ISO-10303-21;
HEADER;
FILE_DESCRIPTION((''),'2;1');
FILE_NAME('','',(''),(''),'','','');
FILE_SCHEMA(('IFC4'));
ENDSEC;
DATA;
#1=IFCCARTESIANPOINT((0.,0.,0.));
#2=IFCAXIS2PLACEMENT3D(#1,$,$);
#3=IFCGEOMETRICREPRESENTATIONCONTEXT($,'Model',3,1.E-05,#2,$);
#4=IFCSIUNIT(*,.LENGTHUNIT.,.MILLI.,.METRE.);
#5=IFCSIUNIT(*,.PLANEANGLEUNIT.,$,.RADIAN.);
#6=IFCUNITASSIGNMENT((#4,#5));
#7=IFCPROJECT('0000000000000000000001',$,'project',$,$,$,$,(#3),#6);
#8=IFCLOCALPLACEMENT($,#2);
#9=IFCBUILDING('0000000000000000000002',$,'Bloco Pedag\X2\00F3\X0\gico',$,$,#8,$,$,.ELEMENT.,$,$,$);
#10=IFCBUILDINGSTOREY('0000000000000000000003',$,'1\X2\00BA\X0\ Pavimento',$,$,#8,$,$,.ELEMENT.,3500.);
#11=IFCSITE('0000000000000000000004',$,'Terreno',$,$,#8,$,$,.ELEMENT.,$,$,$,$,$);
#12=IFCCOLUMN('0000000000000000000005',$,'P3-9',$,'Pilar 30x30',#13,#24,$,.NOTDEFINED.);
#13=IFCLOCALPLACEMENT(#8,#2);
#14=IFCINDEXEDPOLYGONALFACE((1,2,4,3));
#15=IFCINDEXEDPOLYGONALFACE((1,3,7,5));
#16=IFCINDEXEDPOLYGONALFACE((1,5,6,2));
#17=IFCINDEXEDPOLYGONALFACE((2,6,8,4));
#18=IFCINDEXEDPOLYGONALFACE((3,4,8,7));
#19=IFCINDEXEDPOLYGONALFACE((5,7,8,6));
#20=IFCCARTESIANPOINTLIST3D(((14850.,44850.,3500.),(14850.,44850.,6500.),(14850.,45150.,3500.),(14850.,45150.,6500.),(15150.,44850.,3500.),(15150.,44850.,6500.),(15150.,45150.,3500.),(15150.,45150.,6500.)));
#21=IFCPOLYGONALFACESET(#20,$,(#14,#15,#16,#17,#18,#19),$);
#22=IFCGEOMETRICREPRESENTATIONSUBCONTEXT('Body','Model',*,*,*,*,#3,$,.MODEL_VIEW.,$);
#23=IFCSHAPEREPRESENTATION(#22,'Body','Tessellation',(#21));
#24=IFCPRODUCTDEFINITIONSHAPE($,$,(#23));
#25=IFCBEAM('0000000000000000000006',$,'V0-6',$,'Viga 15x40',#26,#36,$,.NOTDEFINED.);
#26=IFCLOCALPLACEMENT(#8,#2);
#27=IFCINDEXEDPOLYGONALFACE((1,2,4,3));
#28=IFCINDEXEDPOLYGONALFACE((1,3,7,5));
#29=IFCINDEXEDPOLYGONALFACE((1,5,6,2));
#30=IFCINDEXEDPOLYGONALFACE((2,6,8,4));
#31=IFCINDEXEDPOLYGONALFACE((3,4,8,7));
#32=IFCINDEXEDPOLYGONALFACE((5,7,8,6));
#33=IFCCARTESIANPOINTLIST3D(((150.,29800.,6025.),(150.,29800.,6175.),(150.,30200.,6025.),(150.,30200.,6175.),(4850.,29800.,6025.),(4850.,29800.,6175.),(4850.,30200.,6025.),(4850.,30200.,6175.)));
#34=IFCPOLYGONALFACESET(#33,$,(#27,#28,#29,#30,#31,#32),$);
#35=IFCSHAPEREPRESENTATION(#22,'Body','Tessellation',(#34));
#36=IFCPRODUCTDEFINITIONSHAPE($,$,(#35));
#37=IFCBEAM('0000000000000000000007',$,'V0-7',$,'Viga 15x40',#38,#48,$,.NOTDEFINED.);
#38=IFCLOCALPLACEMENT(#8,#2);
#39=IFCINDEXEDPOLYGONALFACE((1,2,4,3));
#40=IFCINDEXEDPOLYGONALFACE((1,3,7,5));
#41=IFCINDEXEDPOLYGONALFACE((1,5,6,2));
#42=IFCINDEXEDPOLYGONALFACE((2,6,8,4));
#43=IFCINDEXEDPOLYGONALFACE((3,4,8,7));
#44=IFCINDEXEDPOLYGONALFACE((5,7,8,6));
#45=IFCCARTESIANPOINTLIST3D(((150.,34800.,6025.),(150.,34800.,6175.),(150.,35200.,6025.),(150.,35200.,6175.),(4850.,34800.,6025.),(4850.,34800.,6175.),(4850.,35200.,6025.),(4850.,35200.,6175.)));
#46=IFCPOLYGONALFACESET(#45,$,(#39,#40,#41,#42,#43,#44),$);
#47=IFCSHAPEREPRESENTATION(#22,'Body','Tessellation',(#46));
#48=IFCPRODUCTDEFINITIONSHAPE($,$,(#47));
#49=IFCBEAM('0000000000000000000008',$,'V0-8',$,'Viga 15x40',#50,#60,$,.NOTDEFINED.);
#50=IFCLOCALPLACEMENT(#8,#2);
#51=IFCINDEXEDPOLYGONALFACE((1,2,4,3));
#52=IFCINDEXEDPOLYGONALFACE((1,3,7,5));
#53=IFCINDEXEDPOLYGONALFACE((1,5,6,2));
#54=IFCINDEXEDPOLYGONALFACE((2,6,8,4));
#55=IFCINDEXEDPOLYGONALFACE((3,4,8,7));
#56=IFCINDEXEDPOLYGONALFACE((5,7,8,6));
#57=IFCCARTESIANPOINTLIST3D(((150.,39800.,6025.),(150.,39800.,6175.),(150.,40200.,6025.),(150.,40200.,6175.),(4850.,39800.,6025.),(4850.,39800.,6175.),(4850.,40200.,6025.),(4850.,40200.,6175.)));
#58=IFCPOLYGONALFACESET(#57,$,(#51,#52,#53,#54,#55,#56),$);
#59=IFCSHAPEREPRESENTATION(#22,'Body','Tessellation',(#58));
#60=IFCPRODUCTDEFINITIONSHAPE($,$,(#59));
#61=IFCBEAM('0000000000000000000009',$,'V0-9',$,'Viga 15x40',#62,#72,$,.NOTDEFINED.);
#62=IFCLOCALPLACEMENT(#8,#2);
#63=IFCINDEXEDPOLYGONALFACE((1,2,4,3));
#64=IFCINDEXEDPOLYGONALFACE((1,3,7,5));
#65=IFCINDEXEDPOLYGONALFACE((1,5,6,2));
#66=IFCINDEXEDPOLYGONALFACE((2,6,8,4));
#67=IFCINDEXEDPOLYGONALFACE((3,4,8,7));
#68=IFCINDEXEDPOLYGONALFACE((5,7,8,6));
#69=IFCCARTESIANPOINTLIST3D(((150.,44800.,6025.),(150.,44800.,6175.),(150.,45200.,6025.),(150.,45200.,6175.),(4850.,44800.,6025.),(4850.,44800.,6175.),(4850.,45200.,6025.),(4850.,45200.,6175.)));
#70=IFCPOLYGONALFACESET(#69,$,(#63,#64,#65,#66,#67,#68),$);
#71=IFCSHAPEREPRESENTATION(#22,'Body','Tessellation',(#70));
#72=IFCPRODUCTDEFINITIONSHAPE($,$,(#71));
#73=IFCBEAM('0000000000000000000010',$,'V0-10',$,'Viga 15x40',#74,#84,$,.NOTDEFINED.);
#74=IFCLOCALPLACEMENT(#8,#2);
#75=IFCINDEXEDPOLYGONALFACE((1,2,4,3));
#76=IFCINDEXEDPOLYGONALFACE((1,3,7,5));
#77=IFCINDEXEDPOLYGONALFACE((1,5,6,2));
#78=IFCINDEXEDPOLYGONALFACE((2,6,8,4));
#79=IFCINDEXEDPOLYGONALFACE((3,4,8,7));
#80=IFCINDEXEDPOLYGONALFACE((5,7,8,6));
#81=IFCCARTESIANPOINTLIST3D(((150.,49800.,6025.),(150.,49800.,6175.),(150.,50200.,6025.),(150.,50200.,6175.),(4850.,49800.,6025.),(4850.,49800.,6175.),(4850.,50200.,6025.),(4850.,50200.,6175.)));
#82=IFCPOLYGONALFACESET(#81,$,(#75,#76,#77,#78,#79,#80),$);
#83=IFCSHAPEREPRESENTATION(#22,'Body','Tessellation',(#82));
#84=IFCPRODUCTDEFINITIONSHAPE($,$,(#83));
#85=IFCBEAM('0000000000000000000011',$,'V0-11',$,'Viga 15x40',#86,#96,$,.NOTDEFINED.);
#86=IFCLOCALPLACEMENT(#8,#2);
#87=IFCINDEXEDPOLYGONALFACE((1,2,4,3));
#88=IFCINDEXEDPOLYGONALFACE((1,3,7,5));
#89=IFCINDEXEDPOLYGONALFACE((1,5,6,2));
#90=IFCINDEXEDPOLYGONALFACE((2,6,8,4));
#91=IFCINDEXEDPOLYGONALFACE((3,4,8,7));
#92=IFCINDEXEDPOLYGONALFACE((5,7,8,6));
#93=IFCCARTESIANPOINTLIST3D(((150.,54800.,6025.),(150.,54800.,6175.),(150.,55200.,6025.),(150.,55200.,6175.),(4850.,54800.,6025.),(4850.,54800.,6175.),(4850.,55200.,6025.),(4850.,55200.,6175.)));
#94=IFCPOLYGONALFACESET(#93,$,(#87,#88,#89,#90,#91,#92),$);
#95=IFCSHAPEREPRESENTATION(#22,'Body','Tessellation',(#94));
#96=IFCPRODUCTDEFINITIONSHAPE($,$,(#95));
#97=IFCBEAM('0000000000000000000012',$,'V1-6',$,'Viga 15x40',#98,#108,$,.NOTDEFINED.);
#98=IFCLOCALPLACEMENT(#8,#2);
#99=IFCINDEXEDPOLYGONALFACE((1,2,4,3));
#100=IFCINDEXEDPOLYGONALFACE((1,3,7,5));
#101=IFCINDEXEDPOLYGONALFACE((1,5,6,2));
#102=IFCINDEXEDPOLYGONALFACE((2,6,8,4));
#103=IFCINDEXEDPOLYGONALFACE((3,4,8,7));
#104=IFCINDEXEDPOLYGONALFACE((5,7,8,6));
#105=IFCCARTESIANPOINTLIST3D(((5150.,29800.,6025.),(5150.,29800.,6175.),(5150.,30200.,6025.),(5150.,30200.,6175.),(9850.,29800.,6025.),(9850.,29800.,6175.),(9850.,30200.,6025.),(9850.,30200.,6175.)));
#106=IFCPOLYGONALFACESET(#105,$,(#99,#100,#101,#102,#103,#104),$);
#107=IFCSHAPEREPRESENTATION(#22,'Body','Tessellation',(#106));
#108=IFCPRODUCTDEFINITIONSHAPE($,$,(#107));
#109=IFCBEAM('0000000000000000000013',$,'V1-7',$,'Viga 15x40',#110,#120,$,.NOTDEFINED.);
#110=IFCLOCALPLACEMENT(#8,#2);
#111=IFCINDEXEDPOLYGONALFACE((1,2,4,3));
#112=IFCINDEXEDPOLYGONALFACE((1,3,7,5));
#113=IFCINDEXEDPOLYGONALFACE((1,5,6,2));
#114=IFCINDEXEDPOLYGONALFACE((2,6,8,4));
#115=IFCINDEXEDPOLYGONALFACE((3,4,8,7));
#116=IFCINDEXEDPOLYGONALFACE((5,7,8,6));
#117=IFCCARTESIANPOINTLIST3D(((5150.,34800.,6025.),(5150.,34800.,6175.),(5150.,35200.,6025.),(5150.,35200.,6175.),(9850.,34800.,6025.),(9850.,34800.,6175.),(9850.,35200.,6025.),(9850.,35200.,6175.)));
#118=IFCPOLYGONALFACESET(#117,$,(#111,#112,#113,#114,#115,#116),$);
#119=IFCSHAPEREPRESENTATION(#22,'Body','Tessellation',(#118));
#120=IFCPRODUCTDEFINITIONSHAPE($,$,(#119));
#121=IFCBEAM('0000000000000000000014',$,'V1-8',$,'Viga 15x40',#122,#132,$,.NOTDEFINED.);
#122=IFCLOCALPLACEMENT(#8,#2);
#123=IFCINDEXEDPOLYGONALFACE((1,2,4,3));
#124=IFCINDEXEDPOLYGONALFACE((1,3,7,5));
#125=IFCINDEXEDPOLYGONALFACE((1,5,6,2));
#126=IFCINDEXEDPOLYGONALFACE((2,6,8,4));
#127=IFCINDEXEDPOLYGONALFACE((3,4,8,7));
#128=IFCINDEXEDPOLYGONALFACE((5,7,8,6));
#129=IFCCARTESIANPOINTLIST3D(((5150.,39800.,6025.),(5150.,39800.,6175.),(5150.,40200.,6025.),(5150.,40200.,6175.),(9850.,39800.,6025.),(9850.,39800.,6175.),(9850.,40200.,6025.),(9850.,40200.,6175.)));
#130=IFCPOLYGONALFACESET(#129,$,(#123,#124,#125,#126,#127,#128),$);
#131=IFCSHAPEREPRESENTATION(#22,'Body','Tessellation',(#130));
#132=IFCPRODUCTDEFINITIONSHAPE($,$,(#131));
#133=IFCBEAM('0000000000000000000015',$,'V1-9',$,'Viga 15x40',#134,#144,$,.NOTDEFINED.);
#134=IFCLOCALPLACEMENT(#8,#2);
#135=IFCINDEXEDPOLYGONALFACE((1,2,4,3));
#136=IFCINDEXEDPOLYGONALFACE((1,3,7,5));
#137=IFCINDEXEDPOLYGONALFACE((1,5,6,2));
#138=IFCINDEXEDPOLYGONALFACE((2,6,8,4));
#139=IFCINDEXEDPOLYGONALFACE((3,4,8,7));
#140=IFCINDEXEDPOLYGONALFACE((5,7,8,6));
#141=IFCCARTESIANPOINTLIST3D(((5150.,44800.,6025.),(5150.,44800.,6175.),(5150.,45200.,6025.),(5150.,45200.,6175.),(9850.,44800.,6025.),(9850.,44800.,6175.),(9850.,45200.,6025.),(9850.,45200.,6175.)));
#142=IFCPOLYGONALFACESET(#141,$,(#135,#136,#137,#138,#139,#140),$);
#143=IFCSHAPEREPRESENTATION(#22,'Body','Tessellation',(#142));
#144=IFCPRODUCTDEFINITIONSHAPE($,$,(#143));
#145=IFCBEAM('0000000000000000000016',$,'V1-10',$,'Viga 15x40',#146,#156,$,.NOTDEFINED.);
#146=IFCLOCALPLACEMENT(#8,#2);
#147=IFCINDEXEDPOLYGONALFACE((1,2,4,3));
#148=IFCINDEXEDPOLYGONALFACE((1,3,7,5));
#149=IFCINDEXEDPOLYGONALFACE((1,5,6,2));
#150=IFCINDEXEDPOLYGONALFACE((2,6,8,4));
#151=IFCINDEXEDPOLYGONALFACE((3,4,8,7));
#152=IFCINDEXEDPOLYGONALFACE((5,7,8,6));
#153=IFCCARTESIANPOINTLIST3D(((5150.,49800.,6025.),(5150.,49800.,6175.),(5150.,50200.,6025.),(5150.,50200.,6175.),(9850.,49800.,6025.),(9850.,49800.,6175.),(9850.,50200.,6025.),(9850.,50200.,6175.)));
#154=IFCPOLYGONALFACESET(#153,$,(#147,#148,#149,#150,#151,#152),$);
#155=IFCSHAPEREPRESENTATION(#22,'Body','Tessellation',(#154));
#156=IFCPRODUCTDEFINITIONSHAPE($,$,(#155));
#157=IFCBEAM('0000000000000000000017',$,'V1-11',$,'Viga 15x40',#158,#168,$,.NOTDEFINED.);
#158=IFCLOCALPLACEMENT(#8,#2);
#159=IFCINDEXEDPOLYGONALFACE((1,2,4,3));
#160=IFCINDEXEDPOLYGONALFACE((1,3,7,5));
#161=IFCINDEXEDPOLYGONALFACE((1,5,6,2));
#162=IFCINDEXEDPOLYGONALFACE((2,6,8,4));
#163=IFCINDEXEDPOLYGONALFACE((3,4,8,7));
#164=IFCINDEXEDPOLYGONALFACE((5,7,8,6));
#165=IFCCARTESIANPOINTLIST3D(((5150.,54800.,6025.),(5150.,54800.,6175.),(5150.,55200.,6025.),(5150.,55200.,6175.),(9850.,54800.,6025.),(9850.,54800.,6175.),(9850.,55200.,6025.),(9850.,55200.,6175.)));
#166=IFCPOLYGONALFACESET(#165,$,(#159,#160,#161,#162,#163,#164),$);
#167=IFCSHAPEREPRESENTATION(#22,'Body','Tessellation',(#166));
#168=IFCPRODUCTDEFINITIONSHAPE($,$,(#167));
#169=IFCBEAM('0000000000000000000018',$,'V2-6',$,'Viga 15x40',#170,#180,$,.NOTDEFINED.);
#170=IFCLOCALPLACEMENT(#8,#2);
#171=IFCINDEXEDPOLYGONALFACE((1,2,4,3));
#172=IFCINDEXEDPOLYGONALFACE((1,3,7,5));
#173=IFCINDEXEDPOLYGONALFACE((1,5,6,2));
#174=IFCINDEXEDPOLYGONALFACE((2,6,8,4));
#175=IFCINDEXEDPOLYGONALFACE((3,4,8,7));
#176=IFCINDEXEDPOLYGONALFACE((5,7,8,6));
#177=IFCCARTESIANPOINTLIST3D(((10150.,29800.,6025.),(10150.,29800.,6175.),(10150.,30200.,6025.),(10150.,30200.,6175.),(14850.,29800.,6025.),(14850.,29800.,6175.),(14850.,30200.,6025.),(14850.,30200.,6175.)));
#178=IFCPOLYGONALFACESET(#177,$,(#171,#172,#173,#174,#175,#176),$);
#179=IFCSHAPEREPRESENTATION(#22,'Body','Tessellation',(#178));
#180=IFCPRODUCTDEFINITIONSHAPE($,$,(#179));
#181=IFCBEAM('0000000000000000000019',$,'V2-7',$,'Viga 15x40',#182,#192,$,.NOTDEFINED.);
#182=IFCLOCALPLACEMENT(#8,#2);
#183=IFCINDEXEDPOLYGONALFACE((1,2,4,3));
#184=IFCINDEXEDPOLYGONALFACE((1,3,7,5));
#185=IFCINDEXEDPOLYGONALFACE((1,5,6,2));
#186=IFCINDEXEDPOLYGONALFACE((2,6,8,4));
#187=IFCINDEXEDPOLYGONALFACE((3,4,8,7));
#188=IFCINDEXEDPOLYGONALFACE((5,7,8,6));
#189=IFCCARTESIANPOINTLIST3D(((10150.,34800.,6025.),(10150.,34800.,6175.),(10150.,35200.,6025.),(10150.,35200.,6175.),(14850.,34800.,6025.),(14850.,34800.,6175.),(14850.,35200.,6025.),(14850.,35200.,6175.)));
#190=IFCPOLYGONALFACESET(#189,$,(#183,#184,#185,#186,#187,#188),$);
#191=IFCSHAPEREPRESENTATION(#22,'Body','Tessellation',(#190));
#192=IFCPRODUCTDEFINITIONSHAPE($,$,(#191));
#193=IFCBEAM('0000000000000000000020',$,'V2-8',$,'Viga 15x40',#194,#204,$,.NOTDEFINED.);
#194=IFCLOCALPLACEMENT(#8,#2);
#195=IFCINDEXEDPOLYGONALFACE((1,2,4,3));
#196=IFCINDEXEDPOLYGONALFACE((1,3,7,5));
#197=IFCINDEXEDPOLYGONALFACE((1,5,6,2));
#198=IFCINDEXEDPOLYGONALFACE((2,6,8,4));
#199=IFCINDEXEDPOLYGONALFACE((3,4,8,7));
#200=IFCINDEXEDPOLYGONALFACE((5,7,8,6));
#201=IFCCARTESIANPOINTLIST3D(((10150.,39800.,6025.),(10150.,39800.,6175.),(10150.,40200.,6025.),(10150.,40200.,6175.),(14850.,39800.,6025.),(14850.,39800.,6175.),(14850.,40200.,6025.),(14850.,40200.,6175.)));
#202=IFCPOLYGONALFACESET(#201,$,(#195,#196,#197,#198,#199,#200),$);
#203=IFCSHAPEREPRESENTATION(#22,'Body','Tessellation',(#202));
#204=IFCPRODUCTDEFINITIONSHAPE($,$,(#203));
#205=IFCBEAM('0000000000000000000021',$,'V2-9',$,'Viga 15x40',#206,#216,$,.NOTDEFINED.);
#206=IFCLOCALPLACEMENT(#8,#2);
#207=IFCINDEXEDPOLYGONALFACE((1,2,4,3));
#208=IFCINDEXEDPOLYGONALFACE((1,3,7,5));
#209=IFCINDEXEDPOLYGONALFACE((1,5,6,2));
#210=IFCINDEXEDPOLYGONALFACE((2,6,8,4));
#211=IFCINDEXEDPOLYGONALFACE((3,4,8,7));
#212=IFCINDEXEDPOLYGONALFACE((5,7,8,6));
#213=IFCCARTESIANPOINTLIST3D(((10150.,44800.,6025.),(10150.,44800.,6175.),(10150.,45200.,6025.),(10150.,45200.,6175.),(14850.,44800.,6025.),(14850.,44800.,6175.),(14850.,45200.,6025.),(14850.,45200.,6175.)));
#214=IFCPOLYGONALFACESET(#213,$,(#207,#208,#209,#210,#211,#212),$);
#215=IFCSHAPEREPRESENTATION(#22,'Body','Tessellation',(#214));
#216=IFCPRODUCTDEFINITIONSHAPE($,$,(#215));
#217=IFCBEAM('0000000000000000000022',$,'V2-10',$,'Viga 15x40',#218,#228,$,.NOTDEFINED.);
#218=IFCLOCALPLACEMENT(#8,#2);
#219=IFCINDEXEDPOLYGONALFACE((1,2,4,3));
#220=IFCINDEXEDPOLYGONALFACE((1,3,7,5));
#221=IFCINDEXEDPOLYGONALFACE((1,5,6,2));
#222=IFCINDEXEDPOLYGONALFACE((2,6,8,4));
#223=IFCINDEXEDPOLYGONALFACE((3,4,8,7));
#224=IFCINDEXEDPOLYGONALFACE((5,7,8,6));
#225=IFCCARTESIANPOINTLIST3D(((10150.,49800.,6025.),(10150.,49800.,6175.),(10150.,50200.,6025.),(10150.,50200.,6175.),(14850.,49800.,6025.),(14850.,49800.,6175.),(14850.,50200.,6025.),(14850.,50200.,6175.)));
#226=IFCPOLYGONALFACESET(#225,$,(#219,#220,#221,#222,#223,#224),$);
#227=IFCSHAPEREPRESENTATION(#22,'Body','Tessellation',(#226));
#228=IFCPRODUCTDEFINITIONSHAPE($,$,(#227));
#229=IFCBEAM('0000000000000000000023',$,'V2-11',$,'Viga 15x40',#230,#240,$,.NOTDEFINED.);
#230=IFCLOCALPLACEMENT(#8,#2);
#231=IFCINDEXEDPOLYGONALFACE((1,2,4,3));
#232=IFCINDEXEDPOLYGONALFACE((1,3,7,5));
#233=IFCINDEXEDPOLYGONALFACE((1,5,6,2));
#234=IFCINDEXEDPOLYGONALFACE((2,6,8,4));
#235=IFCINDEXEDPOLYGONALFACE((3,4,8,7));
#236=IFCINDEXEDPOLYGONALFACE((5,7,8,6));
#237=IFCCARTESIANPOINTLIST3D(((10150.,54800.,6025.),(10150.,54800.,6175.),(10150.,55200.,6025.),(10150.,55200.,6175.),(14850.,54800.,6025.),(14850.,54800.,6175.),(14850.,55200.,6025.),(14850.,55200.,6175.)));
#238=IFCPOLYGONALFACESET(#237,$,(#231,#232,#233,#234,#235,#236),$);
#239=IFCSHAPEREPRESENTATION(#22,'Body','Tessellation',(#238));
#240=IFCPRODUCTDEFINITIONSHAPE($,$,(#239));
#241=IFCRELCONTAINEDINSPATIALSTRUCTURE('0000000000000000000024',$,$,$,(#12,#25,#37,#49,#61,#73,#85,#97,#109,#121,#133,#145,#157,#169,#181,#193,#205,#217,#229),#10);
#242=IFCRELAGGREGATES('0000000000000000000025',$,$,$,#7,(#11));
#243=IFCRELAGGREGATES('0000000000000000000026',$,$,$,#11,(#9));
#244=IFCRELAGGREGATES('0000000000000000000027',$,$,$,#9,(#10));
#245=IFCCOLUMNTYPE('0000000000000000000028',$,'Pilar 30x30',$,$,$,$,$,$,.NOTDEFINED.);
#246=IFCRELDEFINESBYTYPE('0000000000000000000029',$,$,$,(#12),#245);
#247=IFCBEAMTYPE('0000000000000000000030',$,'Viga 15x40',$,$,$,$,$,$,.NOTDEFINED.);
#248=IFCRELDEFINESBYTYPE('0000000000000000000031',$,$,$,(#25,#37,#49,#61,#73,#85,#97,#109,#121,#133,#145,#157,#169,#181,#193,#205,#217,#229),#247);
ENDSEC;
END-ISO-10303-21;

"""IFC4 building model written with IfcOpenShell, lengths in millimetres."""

from ifc_helpers import new_model, si_unit, frame, origin, origin_2d, place, context, subcontext, project, spatial, rectangle, extrude, type_object, element, save


model = new_model("IFC4")

# Units and contexts
model_context = context("Model", 3, precision=1e-05, world=origin())
body_context = subcontext(model_context, "Body", "Model", "MODEL_VIEW")
ifc_project = project(units=[si_unit("LENGTHUNIT", "METRE", prefix="MILLI"), si_unit("PLANEANGLEUNIT", "RADIAN")], contexts=[model_context])

# Site, building, storey
placement = place(None, origin())
site = spatial("IfcSite", under=ifc_project, at=placement, Name="Terreno", CompositionType="ELEMENT")
building = spatial("IfcBuilding", under=site, at=placement, Name="Bloco Pedagógico", CompositionType="ELEMENT")
storey = spatial("IfcBuildingStorey", under=building, at=placement, Name="1º Pavimento", CompositionType="ELEMENT", Elevation=3500.0)

# Column
column_type = type_object("IfcColumnType", Name="Pilar 30x30", PredefinedType="NOTDEFINED")
for number, where, z_axis, x_axis, name in (
    (1, (15000.0, 45000.0, 3500.0), (0.0, 0.0, 1.0), (1.0, 0.0, 0.0), "P3-9"),
):
    element("IfcColumn", number, at=place(None, frame(where, z_axis=z_axis, x_axis=x_axis)), inside=storey, type_object=column_type, Name=name, ObjectType="Pilar 30x30", PredefinedType="NOTDEFINED", context=body_context, shape_type="SweptSolid", body=[
        extrude(rectangle(XDim=300.0, YDim=300.0, at=origin_2d()), None, (0.0, 0.0, 1.0), 3000.0),
    ])

# Beams
beam_type = type_object("IfcBeamType", Name="Viga 15x40", PredefinedType="NOTDEFINED")
for number, where, z_axis, x_axis, name in (
    (2, (150.0, 30000.0, 6100.0), (1.0, 0.0, 0.0), (0.0, 1.0, 0.0), "V0-6"),
    (3, (150.0, 35000.0, 6100.0), (1.0, 0.0, 0.0), (0.0, 1.0, 0.0), "V0-7"),
    (4, (150.0, 40000.0, 6100.0), (1.0, 0.0, 0.0), (0.0, 1.0, 0.0), "V0-8"),
    (5, (150.0, 45000.0, 6100.0), (1.0, 0.0, 0.0), (0.0, 1.0, 0.0), "V0-9"),
    (6, (150.0, 50000.0, 6100.0), (1.0, 0.0, 0.0), (0.0, 1.0, 0.0), "V0-10"),
    (7, (150.0, 55000.0, 6100.0), (1.0, 0.0, 0.0), (0.0, 1.0, 0.0), "V0-11"),
    (8, (5150.0, 30000.0, 6100.0), (1.0, 0.0, 0.0), (0.0, 1.0, 0.0), "V1-6"),
    (9, (5150.0, 35000.0, 6100.0), (1.0, 0.0, 0.0), (0.0, 1.0, 0.0), "V1-7"),
    (10, (5150.0, 40000.0, 6100.0), (1.0, 0.0, 0.0), (0.0, 1.0, 0.0), "V1-8"),
    (11, (5150.0, 45000.0, 6100.0), (1.0, 0.0, 0.0), (0.0, 1.0, 0.0), "V1-9"),
    (12, (5150.0, 50000.0, 6100.0), (1.0, 0.0, 0.0), (0.0, 1.0, 0.0), "V1-10"),
    (13, (5150.0, 55000.0, 6100.0), (1.0, 0.0, 0.0), (0.0, 1.0, 0.0), "V1-11"),
    (14, (10150.0, 30000.0, 6100.0), (1.0, 0.0, 0.0), (0.0, 1.0, 0.0), "V2-6"),
    (15, (10150.0, 35000.0, 6100.0), (1.0, 0.0, 0.0), (0.0, 1.0, 0.0), "V2-7"),
    (16, (10150.0, 40000.0, 6100.0), (1.0, 0.0, 0.0), (0.0, 1.0, 0.0), "V2-8"),
    (17, (10150.0, 45000.0, 6100.0), (1.0, 0.0, 0.0), (0.0, 1.0, 0.0), "V2-9"),
    (18, (10150.0, 50000.0, 6100.0), (1.0, 0.0, 0.0), (0.0, 1.0, 0.0), "V2-10"),
    (19, (10150.0, 55000.0, 6100.0), (1.0, 0.0, 0.0), (0.0, 1.0, 0.0), "V2-11"),
):
    element("IfcBeam", number, at=place(None, frame(where, z_axis=z_axis, x_axis=x_axis)), inside=storey, type_object=beam_type, Name=name, ObjectType="Viga 15x40", PredefinedType="NOTDEFINED", context=body_context, shape_type="SweptSolid", body=[
        extrude(rectangle(XDim=400.0, YDim=150.0, at=origin_2d()), None, (0.0, 0.0, 1.0), 4700.0),
    ])

save(model, "model.ifc")
